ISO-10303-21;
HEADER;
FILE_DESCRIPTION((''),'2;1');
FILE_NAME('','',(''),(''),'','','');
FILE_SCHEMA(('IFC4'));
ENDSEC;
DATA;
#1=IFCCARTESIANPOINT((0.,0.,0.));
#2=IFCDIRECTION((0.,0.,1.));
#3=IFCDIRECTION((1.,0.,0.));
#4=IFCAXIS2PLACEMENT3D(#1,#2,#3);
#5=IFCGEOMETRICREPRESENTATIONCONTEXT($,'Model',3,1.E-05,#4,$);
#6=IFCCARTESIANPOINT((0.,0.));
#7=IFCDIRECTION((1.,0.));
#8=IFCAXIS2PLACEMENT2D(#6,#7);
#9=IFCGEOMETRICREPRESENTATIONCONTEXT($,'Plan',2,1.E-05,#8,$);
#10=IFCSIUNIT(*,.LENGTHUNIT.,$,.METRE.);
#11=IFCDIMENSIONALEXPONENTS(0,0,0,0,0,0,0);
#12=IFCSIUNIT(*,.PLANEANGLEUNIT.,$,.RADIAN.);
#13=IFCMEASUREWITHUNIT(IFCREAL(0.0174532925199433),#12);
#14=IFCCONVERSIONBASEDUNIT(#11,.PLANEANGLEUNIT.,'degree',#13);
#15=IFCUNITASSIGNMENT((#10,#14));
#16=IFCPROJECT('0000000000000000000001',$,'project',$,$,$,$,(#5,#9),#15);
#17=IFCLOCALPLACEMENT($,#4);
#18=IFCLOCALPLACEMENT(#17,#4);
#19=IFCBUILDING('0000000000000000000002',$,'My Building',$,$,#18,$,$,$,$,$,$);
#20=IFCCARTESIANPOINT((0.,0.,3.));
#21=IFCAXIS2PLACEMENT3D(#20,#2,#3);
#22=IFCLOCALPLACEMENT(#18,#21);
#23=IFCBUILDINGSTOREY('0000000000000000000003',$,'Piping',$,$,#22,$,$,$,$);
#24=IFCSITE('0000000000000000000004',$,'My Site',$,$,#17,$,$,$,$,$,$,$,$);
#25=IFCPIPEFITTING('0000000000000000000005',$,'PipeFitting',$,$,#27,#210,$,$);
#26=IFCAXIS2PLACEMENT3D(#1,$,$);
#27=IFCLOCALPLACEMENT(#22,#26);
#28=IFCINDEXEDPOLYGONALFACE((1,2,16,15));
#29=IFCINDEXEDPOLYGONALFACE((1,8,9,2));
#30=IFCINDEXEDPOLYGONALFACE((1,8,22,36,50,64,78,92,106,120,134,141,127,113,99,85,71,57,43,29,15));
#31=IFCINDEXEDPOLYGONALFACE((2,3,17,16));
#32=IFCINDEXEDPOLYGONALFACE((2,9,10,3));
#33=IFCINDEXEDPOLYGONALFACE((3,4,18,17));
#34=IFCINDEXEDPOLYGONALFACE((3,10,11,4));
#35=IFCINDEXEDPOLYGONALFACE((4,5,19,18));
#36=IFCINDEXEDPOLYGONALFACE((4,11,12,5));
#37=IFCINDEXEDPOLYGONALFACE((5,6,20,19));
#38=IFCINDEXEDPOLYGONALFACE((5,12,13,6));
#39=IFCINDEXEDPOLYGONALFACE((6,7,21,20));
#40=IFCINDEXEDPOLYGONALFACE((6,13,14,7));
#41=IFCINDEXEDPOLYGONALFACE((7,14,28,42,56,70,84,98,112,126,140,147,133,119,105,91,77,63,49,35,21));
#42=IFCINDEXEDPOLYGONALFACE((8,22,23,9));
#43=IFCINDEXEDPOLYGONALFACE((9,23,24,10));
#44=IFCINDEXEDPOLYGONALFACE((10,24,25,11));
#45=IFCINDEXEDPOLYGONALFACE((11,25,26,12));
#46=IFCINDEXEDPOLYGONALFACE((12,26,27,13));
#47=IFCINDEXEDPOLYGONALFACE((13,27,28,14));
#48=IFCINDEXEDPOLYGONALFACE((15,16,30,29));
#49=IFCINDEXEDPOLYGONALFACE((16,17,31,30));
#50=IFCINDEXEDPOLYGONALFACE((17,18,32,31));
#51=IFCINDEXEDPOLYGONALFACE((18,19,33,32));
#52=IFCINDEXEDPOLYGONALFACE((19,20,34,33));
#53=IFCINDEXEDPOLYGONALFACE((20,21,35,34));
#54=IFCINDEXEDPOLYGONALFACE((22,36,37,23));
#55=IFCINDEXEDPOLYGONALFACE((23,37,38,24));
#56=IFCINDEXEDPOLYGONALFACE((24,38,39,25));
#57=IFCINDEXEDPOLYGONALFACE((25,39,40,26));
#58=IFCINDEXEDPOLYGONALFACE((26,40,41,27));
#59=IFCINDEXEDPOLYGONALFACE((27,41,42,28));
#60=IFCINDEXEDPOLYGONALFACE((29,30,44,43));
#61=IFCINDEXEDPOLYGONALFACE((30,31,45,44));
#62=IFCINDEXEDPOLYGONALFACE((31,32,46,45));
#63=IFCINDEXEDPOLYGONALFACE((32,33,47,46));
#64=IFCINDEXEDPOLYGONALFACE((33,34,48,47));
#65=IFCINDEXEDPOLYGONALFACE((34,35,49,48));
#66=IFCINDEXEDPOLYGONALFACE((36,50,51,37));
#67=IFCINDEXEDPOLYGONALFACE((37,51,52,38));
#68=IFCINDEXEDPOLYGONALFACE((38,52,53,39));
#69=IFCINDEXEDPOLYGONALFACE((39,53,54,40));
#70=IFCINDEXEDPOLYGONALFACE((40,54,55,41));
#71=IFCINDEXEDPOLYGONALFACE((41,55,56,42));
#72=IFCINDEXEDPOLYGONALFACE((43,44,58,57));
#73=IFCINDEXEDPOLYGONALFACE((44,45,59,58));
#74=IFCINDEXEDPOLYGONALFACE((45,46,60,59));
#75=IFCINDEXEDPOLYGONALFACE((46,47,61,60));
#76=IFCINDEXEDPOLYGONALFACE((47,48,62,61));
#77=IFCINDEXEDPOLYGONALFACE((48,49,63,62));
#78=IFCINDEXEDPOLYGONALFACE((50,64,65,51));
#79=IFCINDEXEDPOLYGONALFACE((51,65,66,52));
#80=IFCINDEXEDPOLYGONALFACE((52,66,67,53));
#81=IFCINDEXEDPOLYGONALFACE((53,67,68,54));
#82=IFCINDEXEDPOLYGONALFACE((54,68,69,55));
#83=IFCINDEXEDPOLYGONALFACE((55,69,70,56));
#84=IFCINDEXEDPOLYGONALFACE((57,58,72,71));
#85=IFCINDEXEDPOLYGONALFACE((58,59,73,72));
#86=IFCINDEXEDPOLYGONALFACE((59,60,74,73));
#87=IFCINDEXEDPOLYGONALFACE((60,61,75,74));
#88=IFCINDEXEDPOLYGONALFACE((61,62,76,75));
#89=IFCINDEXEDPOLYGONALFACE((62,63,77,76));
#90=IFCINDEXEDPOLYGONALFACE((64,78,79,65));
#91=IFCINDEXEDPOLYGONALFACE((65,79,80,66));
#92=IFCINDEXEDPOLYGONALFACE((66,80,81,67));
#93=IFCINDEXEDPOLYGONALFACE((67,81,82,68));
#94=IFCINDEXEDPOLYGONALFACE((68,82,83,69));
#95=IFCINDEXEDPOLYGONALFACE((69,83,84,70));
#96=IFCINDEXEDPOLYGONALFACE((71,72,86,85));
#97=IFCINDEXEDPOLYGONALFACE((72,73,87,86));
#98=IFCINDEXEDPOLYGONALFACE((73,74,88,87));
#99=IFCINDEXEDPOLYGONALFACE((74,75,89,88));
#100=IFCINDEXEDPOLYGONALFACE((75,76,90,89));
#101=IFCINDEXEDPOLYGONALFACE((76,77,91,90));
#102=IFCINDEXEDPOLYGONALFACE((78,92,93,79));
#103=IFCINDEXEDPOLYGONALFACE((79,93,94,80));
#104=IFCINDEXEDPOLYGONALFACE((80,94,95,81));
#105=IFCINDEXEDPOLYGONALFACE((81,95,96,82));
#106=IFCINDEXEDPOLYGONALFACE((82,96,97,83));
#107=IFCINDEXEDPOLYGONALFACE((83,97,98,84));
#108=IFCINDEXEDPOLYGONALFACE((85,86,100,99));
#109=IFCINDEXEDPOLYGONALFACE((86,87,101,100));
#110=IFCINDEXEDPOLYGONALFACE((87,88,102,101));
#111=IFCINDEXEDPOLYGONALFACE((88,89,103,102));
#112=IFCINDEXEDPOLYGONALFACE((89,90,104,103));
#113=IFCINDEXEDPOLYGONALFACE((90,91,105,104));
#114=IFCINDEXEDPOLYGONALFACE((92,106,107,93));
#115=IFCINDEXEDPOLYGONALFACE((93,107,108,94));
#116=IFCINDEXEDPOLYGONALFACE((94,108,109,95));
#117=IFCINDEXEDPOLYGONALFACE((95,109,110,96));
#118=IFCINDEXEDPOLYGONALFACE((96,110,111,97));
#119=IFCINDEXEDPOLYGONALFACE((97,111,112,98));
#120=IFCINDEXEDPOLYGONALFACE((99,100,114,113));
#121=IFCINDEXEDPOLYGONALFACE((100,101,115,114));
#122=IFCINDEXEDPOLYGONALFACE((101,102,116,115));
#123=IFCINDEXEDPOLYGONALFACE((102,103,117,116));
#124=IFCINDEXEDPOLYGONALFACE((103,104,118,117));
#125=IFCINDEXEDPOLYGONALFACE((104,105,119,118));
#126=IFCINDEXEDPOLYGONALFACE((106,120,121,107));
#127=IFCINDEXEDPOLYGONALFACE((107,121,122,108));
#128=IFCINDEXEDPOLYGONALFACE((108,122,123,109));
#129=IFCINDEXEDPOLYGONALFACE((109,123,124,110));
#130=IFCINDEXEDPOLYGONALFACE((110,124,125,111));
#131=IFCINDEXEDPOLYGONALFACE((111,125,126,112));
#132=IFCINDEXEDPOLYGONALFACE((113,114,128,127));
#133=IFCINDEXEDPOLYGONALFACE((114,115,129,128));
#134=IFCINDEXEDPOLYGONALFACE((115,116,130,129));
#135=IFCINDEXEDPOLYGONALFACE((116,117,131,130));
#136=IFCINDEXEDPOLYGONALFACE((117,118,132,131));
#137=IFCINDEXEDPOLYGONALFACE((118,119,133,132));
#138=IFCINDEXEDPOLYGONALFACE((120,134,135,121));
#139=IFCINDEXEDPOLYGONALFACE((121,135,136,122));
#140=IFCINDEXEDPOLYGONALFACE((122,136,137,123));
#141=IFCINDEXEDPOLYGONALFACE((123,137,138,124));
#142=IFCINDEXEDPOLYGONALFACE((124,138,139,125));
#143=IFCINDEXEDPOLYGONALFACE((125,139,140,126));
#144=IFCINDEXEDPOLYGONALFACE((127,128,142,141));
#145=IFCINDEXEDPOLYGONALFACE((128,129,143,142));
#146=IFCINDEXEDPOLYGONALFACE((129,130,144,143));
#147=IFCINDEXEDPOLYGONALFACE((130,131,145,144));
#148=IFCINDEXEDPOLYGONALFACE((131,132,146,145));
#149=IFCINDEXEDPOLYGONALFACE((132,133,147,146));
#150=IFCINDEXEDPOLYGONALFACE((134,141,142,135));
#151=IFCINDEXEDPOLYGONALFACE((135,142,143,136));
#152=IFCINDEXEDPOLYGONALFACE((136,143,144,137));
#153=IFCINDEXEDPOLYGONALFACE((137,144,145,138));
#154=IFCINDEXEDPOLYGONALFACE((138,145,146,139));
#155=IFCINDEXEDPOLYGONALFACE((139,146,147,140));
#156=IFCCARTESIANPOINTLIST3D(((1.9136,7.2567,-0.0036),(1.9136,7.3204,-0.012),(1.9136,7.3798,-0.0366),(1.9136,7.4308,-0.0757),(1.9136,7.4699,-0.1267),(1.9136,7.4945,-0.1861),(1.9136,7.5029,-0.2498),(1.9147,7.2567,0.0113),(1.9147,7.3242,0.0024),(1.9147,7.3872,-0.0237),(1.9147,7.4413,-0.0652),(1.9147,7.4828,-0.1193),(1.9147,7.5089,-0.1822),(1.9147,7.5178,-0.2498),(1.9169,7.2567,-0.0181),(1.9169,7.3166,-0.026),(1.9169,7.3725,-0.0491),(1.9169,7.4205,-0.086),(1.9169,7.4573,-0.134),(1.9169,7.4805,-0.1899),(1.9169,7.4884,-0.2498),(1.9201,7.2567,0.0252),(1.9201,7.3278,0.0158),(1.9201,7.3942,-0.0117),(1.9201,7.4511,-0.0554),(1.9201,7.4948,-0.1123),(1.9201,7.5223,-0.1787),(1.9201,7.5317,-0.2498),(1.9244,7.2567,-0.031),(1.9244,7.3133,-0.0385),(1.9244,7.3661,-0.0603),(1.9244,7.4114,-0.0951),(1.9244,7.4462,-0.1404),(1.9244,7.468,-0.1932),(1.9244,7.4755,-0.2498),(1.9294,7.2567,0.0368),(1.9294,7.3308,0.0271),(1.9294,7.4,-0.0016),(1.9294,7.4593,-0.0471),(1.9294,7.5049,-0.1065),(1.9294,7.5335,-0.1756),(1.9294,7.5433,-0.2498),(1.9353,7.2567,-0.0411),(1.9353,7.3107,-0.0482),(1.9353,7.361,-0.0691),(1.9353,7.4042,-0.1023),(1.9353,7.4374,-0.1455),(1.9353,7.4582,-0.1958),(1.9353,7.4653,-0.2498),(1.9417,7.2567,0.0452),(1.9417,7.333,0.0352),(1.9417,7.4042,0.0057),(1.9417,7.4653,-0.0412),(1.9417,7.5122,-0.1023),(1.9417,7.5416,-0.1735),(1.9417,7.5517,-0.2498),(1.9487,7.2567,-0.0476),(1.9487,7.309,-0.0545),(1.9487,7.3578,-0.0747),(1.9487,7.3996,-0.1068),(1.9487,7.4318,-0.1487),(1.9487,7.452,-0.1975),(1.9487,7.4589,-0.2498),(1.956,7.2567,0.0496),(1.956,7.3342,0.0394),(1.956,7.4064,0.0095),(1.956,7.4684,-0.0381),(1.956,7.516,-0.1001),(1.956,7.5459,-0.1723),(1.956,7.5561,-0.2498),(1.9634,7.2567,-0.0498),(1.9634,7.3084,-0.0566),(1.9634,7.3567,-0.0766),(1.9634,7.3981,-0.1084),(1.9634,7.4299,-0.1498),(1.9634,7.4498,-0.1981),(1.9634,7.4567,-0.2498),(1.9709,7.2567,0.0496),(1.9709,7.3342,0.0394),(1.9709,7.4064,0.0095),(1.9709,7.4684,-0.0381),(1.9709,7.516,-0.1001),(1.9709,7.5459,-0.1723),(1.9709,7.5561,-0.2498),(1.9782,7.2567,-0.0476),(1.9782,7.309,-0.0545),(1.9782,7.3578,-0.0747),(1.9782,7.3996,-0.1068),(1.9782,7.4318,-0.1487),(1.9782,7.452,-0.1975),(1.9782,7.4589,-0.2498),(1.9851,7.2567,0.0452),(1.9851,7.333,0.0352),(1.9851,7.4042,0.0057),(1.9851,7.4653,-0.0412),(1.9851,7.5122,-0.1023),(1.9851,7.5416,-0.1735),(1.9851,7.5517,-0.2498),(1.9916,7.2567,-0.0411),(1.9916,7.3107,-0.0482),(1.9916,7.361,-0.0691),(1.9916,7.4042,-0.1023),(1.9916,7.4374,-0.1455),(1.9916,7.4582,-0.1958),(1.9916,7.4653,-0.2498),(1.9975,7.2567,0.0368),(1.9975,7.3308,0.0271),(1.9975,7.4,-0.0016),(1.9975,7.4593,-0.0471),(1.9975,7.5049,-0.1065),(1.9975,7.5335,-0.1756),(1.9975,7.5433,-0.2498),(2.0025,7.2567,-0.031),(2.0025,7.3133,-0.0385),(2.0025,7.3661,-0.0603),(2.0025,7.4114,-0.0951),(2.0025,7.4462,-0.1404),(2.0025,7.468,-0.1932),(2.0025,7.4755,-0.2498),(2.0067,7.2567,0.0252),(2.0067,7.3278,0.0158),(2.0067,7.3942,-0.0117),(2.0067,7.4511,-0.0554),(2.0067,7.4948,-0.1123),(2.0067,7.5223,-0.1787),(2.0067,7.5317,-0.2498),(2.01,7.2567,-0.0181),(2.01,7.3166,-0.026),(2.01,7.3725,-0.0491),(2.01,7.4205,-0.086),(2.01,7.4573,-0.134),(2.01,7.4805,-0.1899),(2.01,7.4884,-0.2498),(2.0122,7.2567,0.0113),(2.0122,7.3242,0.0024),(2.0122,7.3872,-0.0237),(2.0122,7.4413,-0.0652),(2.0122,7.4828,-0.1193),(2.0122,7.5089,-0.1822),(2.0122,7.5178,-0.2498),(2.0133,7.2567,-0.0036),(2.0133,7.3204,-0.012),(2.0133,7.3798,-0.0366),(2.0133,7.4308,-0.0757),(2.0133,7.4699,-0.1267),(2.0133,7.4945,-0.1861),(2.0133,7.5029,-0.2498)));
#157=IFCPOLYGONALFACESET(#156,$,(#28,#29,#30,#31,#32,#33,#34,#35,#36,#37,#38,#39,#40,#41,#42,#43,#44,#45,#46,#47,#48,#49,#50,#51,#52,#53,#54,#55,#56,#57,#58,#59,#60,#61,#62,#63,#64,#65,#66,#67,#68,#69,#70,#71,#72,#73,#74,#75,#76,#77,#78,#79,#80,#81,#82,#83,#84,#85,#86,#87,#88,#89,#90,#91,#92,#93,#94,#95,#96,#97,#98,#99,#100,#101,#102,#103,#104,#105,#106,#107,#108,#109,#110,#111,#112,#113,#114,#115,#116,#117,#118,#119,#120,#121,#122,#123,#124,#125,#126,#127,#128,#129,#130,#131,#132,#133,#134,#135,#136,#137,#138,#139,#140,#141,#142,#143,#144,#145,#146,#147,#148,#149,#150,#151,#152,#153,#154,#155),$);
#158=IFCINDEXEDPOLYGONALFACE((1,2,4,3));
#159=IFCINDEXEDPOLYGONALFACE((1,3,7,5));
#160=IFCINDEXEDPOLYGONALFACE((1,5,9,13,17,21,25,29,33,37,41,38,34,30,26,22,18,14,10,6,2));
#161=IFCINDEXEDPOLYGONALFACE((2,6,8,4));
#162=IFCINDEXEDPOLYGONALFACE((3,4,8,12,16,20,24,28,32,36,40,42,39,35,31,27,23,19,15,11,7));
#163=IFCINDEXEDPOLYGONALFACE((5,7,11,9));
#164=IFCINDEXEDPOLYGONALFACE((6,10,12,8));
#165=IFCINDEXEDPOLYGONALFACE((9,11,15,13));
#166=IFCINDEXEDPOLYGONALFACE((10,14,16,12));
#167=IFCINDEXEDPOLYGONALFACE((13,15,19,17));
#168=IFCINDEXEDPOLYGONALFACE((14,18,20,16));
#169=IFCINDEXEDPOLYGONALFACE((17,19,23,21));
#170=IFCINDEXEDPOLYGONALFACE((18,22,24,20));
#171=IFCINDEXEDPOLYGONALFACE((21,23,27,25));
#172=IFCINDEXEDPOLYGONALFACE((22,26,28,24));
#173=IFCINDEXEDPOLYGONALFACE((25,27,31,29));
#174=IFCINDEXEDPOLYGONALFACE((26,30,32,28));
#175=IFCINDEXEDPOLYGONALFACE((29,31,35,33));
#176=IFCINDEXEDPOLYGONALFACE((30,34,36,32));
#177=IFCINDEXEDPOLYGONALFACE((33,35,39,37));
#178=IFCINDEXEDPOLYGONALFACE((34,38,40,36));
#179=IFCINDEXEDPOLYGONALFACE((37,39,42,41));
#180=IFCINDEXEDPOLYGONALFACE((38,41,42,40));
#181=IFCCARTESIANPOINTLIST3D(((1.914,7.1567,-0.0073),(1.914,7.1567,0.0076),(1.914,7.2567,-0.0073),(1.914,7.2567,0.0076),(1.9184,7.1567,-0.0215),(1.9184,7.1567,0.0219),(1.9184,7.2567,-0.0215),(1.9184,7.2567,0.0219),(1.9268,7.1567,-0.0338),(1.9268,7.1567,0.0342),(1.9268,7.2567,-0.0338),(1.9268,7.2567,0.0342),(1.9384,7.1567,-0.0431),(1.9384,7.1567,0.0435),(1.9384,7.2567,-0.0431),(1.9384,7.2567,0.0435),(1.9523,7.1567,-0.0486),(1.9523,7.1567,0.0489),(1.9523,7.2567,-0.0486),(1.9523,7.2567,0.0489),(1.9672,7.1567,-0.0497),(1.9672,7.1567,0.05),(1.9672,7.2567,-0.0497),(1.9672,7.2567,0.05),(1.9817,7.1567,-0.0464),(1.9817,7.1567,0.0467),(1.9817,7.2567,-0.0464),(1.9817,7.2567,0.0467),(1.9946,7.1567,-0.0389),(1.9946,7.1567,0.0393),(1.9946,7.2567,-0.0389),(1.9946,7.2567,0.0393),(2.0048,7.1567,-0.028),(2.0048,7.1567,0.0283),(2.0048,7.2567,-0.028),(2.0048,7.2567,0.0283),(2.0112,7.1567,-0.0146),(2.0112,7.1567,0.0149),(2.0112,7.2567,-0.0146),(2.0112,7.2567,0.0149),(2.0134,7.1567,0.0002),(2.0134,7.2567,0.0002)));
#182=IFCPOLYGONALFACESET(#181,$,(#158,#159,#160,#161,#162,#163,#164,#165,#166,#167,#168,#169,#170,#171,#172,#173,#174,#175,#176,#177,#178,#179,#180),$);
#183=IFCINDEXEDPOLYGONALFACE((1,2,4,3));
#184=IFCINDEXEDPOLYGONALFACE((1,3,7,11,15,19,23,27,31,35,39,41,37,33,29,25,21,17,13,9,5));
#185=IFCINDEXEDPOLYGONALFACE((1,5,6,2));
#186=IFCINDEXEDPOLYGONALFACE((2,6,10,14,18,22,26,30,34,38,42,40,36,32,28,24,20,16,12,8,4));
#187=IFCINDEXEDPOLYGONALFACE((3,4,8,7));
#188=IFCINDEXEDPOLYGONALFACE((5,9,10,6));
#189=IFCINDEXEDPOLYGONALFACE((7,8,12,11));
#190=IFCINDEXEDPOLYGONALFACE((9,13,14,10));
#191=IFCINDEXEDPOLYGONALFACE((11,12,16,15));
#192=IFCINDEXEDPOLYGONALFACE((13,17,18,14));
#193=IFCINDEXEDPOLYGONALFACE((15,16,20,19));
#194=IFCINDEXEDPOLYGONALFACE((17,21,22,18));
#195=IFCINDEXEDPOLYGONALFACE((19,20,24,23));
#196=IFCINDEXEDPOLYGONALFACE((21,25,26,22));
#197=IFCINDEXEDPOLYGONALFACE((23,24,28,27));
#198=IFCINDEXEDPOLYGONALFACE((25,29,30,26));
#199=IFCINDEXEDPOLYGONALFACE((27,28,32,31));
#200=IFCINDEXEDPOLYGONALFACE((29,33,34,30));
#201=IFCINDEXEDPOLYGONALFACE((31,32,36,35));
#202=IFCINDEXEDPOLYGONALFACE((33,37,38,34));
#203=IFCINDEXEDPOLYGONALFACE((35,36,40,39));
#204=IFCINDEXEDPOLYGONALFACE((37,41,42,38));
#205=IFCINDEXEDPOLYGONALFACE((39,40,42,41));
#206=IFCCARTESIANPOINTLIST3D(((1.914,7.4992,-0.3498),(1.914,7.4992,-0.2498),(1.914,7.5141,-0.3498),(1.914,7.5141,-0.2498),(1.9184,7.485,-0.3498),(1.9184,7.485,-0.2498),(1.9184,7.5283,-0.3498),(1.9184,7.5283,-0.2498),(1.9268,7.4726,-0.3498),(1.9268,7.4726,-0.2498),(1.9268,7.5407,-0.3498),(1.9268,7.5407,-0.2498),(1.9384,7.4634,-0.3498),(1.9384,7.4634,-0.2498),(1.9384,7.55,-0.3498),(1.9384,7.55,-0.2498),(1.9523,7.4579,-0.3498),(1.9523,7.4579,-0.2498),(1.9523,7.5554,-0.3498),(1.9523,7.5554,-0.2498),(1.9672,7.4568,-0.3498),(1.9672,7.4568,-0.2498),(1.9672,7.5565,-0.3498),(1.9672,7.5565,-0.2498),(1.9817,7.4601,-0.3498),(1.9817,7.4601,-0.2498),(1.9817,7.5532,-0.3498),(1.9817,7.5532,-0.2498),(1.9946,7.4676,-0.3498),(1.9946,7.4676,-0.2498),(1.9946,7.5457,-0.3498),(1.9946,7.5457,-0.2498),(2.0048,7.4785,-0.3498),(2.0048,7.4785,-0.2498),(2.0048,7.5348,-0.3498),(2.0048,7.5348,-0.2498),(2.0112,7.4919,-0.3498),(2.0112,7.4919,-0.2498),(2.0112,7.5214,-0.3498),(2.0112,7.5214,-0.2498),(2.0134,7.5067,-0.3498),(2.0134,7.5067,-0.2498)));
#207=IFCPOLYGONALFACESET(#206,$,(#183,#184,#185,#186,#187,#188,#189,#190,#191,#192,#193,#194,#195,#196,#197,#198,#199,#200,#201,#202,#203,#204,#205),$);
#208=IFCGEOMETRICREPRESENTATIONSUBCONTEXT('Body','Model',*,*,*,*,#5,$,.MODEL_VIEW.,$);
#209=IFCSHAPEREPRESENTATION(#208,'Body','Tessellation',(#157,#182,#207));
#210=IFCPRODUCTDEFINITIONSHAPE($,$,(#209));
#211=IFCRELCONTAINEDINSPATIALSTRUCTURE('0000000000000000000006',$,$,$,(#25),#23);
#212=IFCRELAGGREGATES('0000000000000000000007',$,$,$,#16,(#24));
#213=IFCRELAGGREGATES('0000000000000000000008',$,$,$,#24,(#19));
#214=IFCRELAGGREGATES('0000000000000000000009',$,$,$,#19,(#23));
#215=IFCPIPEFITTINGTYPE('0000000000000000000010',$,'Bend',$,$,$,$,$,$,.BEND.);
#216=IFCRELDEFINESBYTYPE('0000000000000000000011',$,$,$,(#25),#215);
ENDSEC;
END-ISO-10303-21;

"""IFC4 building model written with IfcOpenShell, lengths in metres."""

from ifc_helpers import new_model, entity, si_unit, converted_unit, frame, origin_with_axes, origin_2d_with_axis, place, context, subcontext, project, spatial, circle, extrude, source, transform, mapped, type_object, type_shapes, element, save


model = new_model("IFC4")

# Units and contexts
model_context = context("Model", 3, precision=1e-05, world=origin_with_axes())
plan_context = context("Plan", 2, precision=1e-05, world=origin_2d_with_axis())
body_context = subcontext(model_context, "Body", "Model", "MODEL_VIEW")
ifc_project = project(units=[si_unit("LENGTHUNIT", "METRE"), converted_unit("PLANEANGLEUNIT", "degree", entity("IfcReal", 0.0174532925199433), si_unit("PLANEANGLEUNIT", "RADIAN"), dimensions=[0, 0, 0, 0, 0, 0, 0])], contexts=[model_context, plan_context])

# Site, building, storey
site_placement = place(None, origin_with_axes())
site = spatial("IfcSite", under=ifc_project, at=site_placement, Name="My Site")
building_placement = place(site_placement, origin_with_axes())
building = spatial("IfcBuilding", under=site, at=building_placement, Name="My Building")
storey_placement = place(building_placement, frame((0.0, 0.0, 3.0), z_axis=(0.0, 0.0, 1.0), x_axis=(1.0, 0.0, 0.0)))
storey = spatial("IfcBuildingStorey", under=building, at=storey_placement, Name="Piping")

# Pipe fitting
pipe_fitting_type = type_object("IfcPipeFittingType", Name="Bend", PredefinedType="BEND")
shared_shape = source(origin_with_axes(), body_context, "Body", "SolidModel", [
    entity("IfcSweptDiskSolid", entity("IfcIndexedPolyCurve", entity("IfcCartesianPointList3D", [[0.0, 0.0, -0.1], [0.0, -0.0732, -0.2768], [0.0, -0.25, -0.35]]), [entity("IfcArcIndex", [1, 2, 3])]), 0.05),
    extrude(circle(Radius=0.05), origin_with_axes(), (0.0, 0.0, -1.0), 0.1),
    extrude(circle(Radius=0.05), frame((0.0, -0.25, -0.35), z_axis=(0.0, -1.0, 0.0), x_axis=(1.0, 0.0, 0.0)), (0.0, 0.0, 1.0), 0.1),
])
type_shapes(pipe_fitting_type, [shared_shape])
for number, where, z_axis, x_axis, name in (
    (1, (1.9634, 7.1567, 0.0002), (0.0, -1.0, 0.0), (1.0, 0.0, 0.0), "PipeFitting"),
):
    element("IfcPipeFitting", number, at=place(storey_placement, frame(where, z_axis=z_axis, x_axis=x_axis)), inside=storey, type_object=pipe_fitting_type, Name=name, context=body_context, shape_type="MappedRepresentation", body=[
        mapped(shared_shape, transform((0.0, 0.0, 0.0), x_axis=(1.0, 0.0, 0.0), y_axis=(0.0, 1.0, 0.0), z_axis=(0.0, 0.0, 1.0), scale=1.0)),
    ])

save(model, "model.ifc")
